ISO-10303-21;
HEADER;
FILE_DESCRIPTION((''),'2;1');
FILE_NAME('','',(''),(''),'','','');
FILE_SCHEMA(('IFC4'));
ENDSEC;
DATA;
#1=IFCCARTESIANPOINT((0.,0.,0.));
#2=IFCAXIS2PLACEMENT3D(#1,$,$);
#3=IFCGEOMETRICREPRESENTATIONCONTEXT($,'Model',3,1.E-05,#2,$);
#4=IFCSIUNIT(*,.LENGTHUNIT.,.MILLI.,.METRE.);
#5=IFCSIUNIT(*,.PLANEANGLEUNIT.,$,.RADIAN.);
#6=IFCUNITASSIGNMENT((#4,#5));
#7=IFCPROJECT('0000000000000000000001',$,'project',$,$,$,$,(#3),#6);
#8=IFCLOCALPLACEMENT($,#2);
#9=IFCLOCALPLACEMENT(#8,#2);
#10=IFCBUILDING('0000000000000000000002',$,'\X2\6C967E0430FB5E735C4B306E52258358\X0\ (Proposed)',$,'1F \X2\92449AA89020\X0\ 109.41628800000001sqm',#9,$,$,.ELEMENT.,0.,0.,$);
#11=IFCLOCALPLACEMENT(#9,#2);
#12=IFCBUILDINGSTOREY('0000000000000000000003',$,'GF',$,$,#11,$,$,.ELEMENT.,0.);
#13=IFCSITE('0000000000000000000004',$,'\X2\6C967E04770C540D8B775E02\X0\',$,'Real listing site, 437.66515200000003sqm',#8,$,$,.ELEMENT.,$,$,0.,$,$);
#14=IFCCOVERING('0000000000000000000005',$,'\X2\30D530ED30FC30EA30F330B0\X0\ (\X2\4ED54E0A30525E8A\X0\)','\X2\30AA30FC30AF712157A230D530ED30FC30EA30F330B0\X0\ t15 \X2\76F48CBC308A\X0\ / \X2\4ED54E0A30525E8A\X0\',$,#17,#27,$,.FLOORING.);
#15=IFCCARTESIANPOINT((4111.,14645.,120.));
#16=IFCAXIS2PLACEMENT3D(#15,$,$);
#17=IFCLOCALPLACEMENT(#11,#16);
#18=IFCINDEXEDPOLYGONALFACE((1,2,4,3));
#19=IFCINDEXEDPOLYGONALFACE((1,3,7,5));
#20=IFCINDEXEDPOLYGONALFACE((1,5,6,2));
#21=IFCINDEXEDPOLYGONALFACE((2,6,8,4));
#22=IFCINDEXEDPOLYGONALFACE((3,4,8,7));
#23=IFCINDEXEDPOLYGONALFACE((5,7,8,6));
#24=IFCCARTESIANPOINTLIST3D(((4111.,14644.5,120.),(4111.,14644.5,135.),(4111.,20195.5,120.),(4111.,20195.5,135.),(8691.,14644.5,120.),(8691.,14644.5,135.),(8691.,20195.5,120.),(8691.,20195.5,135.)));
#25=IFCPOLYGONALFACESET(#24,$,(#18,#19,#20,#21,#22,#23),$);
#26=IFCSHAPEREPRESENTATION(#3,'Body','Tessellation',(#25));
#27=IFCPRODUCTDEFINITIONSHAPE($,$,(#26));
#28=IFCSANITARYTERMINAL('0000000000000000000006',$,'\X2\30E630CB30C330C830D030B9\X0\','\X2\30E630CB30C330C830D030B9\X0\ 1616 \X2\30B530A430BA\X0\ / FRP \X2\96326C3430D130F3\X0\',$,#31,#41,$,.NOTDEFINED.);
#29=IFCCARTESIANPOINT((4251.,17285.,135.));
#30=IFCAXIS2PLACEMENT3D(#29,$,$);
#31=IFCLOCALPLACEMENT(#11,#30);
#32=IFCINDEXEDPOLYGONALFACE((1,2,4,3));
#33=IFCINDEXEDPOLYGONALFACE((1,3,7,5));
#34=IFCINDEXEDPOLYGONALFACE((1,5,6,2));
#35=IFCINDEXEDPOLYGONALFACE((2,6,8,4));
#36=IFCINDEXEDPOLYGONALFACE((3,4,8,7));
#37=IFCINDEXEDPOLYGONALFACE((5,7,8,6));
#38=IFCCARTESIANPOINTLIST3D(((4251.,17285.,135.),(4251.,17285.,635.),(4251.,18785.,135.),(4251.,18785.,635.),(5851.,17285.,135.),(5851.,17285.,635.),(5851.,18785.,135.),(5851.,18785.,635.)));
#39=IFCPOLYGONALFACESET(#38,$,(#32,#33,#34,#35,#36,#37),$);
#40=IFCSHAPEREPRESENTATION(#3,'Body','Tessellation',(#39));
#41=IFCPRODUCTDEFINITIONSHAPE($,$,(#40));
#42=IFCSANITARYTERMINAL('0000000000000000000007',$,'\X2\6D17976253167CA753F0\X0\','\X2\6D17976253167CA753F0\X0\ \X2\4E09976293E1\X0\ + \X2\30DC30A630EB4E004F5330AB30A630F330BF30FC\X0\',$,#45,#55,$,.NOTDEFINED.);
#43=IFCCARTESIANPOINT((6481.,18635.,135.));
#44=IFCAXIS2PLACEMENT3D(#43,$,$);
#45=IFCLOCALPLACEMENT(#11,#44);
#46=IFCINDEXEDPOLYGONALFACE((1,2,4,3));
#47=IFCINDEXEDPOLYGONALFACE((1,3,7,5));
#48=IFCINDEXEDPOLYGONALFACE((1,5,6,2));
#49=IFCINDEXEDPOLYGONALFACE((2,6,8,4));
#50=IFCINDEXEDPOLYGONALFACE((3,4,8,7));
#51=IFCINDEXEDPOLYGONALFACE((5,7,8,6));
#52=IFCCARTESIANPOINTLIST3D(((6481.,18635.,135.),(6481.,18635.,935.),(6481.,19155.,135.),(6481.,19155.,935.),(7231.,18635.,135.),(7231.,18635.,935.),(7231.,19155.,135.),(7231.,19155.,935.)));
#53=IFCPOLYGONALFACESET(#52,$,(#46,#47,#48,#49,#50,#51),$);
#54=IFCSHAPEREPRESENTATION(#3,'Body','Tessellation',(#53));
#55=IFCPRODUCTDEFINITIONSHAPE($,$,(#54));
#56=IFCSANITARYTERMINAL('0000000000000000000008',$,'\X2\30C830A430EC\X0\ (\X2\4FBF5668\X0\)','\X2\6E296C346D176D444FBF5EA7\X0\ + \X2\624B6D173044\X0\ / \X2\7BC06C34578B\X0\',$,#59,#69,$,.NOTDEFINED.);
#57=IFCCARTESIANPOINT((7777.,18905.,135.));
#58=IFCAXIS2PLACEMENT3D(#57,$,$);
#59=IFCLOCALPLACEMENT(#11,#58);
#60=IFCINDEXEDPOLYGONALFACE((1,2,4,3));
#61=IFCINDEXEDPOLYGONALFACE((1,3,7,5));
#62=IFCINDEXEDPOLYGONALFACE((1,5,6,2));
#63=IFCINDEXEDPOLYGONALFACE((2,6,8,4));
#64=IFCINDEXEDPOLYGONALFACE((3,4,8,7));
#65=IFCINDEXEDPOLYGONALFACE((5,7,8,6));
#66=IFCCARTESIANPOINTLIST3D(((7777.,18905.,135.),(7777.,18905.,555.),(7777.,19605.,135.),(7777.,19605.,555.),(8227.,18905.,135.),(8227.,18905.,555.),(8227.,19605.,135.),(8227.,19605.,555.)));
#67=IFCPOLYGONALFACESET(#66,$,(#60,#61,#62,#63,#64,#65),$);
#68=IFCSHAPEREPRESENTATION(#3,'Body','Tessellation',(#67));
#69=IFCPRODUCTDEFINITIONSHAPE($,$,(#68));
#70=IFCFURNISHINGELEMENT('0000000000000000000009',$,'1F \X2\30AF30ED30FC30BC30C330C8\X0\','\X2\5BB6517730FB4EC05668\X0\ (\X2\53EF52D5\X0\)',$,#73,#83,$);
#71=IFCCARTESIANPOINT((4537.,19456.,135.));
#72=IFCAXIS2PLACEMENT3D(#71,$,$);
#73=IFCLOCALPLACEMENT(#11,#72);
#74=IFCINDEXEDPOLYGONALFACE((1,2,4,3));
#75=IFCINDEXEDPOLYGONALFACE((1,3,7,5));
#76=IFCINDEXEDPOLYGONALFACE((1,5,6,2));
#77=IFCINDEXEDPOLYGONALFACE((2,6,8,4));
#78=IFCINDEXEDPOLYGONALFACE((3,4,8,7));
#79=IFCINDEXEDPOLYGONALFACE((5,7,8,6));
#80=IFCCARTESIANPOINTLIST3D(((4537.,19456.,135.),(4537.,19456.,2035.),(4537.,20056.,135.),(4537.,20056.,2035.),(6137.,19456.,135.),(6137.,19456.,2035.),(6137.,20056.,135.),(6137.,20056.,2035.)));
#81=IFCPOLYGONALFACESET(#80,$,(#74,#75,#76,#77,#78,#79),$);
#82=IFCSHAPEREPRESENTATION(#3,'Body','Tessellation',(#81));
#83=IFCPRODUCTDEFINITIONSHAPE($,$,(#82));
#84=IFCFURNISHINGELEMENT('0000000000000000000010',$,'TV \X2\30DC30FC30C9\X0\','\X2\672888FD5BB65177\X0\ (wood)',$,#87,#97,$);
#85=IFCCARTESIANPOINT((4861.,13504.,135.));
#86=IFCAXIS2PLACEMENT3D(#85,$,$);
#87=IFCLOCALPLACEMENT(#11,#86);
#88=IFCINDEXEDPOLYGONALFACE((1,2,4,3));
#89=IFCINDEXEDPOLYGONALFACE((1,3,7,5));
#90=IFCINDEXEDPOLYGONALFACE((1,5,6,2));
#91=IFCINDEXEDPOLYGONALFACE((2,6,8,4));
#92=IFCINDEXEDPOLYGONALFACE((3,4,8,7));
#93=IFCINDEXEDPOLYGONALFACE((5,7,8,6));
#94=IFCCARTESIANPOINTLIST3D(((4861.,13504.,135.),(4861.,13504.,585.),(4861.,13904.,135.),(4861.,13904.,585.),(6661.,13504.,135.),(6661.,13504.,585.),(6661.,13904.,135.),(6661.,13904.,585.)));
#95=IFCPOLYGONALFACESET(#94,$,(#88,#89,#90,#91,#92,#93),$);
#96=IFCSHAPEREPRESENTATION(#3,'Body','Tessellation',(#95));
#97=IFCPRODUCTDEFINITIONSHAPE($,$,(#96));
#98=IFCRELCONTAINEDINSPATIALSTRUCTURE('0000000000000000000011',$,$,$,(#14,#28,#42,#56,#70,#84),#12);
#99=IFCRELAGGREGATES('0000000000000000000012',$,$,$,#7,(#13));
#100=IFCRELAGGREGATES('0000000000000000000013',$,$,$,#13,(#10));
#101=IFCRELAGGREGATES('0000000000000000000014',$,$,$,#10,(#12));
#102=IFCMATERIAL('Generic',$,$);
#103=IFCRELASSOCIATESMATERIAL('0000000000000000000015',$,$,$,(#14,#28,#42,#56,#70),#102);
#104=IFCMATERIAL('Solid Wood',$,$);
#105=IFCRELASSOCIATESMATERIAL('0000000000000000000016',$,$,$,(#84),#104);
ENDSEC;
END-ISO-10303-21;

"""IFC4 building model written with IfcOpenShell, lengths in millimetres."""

from ifc_helpers import new_model, si_unit, frame, frame_2d, origin, place, context, project, spatial, rectangle, extrude, material, element, save


model = new_model("IFC4")

# Units and contexts
model_context = context("Model", 3, precision=1e-05, world=origin())
ifc_project = project(units=[si_unit("LENGTHUNIT", "METRE", prefix="MILLI"), si_unit("PLANEANGLEUNIT", "RADIAN")], contexts=[model_context])

# Site, building, storey
site_placement = place(None, origin())
site = spatial("IfcSite", under=ifc_project, at=site_placement, Name="沖縄県名護市", ObjectType="Real listing site, 437.66515200000003sqm", CompositionType="ELEMENT", RefElevation=0.0)
building_placement = place(site_placement, origin())
building = spatial("IfcBuilding", under=site, at=building_placement, Name="沖縄・平屋の別荘 (Proposed)", ObjectType="1F 鉄骨造 109.41628800000001sqm", CompositionType="ELEMENT", ElevationOfRefHeight=0.0, ElevationOfTerrain=0.0)
storey_placement = place(building_placement, origin())
storey = spatial("IfcBuildingStorey", under=building, at=storey_placement, Name="GF", CompositionType="ELEMENT", Elevation=0.0)

# Shared definitions
ifc_material_1 = material(Name="Solid Wood")

# Covering
ifc_material_2 = material(Name="Generic")
covering_placement = place(storey_placement, frame((4111.0, 14645.0, 120.0)))
element("IfcCovering", 1, at=covering_placement, inside=storey, material=ifc_material_2, Name="フローリング (仕上げ床)", Description="オーク無垢フローリング t15 直貼り / 仕上げ床", PredefinedType="FLOORING", context=model_context, shape_type="SweptSolid", body=[
    extrude(rectangle(XDim=4580.0, YDim=5551.0, at=frame_2d((2290.0, 2775.0))), frame((4111.0, 14645.0, 120.0)), (0.0, 0.0, 1.0), 15.0),
])

# Sanitary terminals
sanitary_terminal_1_placement = place(storey_placement, frame((4251.0, 17285.0, 135.0)))
element("IfcSanitaryTerminal", 2, at=sanitary_terminal_1_placement, inside=storey, material=ifc_material_2, Name="ユニットバス", Description="ユニットバス 1616 サイズ / FRP 防水パン", PredefinedType="NOTDEFINED", context=model_context, shape_type="SweptSolid", body=[
    extrude(rectangle(XDim=1600.0, YDim=1500.0, at=frame_2d((800.0, 750.0))), frame((4251.0, 17285.0, 135.0)), (0.0, 0.0, 1.0), 500.0),
])
sanitary_terminal_2_placement = place(storey_placement, frame((6481.0, 18635.0, 135.0)))
element("IfcSanitaryTerminal", 3, at=sanitary_terminal_2_placement, inside=storey, material=ifc_material_2, Name="洗面化粧台", Description="洗面化粧台 三面鏡 + ボウル一体カウンター", PredefinedType="NOTDEFINED", context=model_context, shape_type="SweptSolid", body=[
    extrude(rectangle(XDim=750.0, YDim=520.0, at=frame_2d((375.0, 260.0))), frame((6481.0, 18635.0, 135.0)), (0.0, 0.0, 1.0), 800.0),
])
sanitary_terminal_3_placement = place(storey_placement, frame((7777.0, 18905.0, 135.0)))
element("IfcSanitaryTerminal", 4, at=sanitary_terminal_3_placement, inside=storey, material=ifc_material_2, Name="トイレ (便器)", Description="温水洗浄便座 + 手洗い / 節水型", PredefinedType="NOTDEFINED", context=model_context, shape_type="SweptSolid", body=[
    extrude(rectangle(XDim=450.0, YDim=700.0, at=frame_2d((225.0, 350.0))), frame((7777.0, 18905.0, 135.0)), (0.0, 0.0, 1.0), 420.0),
])

# Furnishing elements
furnishing_1_placement = place(storey_placement, frame((4537.0, 19456.0, 135.0)))
element("IfcFurnishingElement", 5, at=furnishing_1_placement, inside=storey, material=ifc_material_2, Name="1F クローゼット", Description="家具・什器 (可動)", context=model_context, shape_type="SweptSolid", body=[
    extrude(rectangle(XDim=1600.0, YDim=600.0, at=frame_2d((800.0, 300.0))), frame((4537.0, 19456.0, 135.0)), (0.0, 0.0, 1.0), 1900.0),
])
furnishing_2_placement = place(storey_placement, frame((4861.0, 13504.0, 135.0)))
element("IfcFurnishingElement", 6, at=furnishing_2_placement, inside=storey, material=ifc_material_1, Name="TV ボード", Description="木製家具 (wood)", context=model_context, shape_type="SweptSolid", body=[
    extrude(rectangle(XDim=1800.0, YDim=400.0, at=frame_2d((900.0, 200.0))), frame((4861.0, 13504.0, 135.0)), (0.0, 0.0, 1.0), 450.0),
])

save(model, "model.ifc")
